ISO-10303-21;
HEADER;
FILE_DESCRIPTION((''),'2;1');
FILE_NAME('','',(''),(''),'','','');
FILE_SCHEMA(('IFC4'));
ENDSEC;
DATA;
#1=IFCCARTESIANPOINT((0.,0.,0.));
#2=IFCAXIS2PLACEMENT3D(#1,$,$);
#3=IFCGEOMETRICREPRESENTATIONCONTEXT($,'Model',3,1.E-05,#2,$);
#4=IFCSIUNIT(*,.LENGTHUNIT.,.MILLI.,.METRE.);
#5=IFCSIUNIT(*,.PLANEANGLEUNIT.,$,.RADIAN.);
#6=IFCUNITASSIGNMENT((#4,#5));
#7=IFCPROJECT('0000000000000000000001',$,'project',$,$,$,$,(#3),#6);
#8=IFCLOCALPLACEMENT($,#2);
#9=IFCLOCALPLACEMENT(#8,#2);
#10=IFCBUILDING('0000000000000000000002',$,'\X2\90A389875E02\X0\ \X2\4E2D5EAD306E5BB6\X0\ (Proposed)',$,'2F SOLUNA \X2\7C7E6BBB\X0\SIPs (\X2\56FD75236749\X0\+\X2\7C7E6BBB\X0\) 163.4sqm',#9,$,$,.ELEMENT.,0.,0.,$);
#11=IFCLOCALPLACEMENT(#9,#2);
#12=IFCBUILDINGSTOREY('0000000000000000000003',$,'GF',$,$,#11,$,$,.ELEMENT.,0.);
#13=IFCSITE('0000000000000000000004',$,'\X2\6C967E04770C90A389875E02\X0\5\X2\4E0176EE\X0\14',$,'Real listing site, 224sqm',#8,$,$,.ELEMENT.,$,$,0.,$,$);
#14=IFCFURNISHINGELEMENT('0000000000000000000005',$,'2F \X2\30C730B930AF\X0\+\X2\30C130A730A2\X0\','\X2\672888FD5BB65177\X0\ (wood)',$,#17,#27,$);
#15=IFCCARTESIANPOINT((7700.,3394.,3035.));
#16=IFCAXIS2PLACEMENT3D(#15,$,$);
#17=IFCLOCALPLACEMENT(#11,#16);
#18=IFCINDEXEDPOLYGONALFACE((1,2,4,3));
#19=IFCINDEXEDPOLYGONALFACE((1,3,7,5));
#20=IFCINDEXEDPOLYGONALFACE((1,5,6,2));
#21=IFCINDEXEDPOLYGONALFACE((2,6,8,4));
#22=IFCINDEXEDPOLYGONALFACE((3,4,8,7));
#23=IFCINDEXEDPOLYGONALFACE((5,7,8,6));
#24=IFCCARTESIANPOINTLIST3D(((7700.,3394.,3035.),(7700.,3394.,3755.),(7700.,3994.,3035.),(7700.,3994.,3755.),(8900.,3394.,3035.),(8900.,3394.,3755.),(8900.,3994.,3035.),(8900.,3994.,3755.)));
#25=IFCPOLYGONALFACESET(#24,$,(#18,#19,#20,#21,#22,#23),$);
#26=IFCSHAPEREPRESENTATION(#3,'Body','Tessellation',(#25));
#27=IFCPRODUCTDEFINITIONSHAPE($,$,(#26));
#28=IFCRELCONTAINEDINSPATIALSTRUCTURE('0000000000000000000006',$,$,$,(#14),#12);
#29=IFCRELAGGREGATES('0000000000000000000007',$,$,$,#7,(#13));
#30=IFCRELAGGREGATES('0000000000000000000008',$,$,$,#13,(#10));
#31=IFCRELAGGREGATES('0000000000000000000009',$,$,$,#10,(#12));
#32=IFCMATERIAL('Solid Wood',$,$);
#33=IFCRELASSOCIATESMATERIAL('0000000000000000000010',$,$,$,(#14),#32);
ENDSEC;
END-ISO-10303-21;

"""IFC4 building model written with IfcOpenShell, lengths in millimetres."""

from ifc_helpers import new_model, si_unit, frame, frame_2d, origin, place, context, project, spatial, rectangle, extrude, material, element, save


model = new_model("IFC4")

# Units and contexts
model_context = context("Model", 3, precision=1e-05, world=origin())
ifc_project = project(units=[si_unit("LENGTHUNIT", "METRE", prefix="MILLI"), si_unit("PLANEANGLEUNIT", "RADIAN")], contexts=[model_context])

# Site, building, storey
site_placement = place(None, origin())
site = spatial("IfcSite", under=ifc_project, at=site_placement, Name="沖縄県那覇市5丁目14", ObjectType="Real listing site, 224sqm", CompositionType="ELEMENT", RefElevation=0.0)
building_placement = place(site_placement, origin())
building = spatial("IfcBuilding", under=site, at=building_placement, Name="那覇市 中庭の家 (Proposed)", ObjectType="2F SOLUNA 籾殻SIPs (国産杉+籾殻) 163.4sqm", CompositionType="ELEMENT", ElevationOfRefHeight=0.0, ElevationOfTerrain=0.0)
storey_placement = place(building_placement, origin())
storey = spatial("IfcBuildingStorey", under=building, at=storey_placement, Name="GF", CompositionType="ELEMENT", Elevation=0.0)

# Shared definitions
ifc_material_1 = material(Name="Solid Wood")

# Furnishing element
furnishing_1_placement = place(storey_placement, frame((7700.0, 3394.0, 3035.0)))
element("IfcFurnishingElement", 1, at=furnishing_1_placement, inside=storey, material=ifc_material_1, Name="2F デスク+チェア", Description="木製家具 (wood)", context=model_context, shape_type="SweptSolid", body=[
    extrude(rectangle(XDim=1200.0, YDim=600.0, at=frame_2d((600.0, 300.0))), frame((7700.0, 3394.0, 3035.0)), (0.0, 0.0, 1.0), 720.0),
])

save(model, "model.ifc")
